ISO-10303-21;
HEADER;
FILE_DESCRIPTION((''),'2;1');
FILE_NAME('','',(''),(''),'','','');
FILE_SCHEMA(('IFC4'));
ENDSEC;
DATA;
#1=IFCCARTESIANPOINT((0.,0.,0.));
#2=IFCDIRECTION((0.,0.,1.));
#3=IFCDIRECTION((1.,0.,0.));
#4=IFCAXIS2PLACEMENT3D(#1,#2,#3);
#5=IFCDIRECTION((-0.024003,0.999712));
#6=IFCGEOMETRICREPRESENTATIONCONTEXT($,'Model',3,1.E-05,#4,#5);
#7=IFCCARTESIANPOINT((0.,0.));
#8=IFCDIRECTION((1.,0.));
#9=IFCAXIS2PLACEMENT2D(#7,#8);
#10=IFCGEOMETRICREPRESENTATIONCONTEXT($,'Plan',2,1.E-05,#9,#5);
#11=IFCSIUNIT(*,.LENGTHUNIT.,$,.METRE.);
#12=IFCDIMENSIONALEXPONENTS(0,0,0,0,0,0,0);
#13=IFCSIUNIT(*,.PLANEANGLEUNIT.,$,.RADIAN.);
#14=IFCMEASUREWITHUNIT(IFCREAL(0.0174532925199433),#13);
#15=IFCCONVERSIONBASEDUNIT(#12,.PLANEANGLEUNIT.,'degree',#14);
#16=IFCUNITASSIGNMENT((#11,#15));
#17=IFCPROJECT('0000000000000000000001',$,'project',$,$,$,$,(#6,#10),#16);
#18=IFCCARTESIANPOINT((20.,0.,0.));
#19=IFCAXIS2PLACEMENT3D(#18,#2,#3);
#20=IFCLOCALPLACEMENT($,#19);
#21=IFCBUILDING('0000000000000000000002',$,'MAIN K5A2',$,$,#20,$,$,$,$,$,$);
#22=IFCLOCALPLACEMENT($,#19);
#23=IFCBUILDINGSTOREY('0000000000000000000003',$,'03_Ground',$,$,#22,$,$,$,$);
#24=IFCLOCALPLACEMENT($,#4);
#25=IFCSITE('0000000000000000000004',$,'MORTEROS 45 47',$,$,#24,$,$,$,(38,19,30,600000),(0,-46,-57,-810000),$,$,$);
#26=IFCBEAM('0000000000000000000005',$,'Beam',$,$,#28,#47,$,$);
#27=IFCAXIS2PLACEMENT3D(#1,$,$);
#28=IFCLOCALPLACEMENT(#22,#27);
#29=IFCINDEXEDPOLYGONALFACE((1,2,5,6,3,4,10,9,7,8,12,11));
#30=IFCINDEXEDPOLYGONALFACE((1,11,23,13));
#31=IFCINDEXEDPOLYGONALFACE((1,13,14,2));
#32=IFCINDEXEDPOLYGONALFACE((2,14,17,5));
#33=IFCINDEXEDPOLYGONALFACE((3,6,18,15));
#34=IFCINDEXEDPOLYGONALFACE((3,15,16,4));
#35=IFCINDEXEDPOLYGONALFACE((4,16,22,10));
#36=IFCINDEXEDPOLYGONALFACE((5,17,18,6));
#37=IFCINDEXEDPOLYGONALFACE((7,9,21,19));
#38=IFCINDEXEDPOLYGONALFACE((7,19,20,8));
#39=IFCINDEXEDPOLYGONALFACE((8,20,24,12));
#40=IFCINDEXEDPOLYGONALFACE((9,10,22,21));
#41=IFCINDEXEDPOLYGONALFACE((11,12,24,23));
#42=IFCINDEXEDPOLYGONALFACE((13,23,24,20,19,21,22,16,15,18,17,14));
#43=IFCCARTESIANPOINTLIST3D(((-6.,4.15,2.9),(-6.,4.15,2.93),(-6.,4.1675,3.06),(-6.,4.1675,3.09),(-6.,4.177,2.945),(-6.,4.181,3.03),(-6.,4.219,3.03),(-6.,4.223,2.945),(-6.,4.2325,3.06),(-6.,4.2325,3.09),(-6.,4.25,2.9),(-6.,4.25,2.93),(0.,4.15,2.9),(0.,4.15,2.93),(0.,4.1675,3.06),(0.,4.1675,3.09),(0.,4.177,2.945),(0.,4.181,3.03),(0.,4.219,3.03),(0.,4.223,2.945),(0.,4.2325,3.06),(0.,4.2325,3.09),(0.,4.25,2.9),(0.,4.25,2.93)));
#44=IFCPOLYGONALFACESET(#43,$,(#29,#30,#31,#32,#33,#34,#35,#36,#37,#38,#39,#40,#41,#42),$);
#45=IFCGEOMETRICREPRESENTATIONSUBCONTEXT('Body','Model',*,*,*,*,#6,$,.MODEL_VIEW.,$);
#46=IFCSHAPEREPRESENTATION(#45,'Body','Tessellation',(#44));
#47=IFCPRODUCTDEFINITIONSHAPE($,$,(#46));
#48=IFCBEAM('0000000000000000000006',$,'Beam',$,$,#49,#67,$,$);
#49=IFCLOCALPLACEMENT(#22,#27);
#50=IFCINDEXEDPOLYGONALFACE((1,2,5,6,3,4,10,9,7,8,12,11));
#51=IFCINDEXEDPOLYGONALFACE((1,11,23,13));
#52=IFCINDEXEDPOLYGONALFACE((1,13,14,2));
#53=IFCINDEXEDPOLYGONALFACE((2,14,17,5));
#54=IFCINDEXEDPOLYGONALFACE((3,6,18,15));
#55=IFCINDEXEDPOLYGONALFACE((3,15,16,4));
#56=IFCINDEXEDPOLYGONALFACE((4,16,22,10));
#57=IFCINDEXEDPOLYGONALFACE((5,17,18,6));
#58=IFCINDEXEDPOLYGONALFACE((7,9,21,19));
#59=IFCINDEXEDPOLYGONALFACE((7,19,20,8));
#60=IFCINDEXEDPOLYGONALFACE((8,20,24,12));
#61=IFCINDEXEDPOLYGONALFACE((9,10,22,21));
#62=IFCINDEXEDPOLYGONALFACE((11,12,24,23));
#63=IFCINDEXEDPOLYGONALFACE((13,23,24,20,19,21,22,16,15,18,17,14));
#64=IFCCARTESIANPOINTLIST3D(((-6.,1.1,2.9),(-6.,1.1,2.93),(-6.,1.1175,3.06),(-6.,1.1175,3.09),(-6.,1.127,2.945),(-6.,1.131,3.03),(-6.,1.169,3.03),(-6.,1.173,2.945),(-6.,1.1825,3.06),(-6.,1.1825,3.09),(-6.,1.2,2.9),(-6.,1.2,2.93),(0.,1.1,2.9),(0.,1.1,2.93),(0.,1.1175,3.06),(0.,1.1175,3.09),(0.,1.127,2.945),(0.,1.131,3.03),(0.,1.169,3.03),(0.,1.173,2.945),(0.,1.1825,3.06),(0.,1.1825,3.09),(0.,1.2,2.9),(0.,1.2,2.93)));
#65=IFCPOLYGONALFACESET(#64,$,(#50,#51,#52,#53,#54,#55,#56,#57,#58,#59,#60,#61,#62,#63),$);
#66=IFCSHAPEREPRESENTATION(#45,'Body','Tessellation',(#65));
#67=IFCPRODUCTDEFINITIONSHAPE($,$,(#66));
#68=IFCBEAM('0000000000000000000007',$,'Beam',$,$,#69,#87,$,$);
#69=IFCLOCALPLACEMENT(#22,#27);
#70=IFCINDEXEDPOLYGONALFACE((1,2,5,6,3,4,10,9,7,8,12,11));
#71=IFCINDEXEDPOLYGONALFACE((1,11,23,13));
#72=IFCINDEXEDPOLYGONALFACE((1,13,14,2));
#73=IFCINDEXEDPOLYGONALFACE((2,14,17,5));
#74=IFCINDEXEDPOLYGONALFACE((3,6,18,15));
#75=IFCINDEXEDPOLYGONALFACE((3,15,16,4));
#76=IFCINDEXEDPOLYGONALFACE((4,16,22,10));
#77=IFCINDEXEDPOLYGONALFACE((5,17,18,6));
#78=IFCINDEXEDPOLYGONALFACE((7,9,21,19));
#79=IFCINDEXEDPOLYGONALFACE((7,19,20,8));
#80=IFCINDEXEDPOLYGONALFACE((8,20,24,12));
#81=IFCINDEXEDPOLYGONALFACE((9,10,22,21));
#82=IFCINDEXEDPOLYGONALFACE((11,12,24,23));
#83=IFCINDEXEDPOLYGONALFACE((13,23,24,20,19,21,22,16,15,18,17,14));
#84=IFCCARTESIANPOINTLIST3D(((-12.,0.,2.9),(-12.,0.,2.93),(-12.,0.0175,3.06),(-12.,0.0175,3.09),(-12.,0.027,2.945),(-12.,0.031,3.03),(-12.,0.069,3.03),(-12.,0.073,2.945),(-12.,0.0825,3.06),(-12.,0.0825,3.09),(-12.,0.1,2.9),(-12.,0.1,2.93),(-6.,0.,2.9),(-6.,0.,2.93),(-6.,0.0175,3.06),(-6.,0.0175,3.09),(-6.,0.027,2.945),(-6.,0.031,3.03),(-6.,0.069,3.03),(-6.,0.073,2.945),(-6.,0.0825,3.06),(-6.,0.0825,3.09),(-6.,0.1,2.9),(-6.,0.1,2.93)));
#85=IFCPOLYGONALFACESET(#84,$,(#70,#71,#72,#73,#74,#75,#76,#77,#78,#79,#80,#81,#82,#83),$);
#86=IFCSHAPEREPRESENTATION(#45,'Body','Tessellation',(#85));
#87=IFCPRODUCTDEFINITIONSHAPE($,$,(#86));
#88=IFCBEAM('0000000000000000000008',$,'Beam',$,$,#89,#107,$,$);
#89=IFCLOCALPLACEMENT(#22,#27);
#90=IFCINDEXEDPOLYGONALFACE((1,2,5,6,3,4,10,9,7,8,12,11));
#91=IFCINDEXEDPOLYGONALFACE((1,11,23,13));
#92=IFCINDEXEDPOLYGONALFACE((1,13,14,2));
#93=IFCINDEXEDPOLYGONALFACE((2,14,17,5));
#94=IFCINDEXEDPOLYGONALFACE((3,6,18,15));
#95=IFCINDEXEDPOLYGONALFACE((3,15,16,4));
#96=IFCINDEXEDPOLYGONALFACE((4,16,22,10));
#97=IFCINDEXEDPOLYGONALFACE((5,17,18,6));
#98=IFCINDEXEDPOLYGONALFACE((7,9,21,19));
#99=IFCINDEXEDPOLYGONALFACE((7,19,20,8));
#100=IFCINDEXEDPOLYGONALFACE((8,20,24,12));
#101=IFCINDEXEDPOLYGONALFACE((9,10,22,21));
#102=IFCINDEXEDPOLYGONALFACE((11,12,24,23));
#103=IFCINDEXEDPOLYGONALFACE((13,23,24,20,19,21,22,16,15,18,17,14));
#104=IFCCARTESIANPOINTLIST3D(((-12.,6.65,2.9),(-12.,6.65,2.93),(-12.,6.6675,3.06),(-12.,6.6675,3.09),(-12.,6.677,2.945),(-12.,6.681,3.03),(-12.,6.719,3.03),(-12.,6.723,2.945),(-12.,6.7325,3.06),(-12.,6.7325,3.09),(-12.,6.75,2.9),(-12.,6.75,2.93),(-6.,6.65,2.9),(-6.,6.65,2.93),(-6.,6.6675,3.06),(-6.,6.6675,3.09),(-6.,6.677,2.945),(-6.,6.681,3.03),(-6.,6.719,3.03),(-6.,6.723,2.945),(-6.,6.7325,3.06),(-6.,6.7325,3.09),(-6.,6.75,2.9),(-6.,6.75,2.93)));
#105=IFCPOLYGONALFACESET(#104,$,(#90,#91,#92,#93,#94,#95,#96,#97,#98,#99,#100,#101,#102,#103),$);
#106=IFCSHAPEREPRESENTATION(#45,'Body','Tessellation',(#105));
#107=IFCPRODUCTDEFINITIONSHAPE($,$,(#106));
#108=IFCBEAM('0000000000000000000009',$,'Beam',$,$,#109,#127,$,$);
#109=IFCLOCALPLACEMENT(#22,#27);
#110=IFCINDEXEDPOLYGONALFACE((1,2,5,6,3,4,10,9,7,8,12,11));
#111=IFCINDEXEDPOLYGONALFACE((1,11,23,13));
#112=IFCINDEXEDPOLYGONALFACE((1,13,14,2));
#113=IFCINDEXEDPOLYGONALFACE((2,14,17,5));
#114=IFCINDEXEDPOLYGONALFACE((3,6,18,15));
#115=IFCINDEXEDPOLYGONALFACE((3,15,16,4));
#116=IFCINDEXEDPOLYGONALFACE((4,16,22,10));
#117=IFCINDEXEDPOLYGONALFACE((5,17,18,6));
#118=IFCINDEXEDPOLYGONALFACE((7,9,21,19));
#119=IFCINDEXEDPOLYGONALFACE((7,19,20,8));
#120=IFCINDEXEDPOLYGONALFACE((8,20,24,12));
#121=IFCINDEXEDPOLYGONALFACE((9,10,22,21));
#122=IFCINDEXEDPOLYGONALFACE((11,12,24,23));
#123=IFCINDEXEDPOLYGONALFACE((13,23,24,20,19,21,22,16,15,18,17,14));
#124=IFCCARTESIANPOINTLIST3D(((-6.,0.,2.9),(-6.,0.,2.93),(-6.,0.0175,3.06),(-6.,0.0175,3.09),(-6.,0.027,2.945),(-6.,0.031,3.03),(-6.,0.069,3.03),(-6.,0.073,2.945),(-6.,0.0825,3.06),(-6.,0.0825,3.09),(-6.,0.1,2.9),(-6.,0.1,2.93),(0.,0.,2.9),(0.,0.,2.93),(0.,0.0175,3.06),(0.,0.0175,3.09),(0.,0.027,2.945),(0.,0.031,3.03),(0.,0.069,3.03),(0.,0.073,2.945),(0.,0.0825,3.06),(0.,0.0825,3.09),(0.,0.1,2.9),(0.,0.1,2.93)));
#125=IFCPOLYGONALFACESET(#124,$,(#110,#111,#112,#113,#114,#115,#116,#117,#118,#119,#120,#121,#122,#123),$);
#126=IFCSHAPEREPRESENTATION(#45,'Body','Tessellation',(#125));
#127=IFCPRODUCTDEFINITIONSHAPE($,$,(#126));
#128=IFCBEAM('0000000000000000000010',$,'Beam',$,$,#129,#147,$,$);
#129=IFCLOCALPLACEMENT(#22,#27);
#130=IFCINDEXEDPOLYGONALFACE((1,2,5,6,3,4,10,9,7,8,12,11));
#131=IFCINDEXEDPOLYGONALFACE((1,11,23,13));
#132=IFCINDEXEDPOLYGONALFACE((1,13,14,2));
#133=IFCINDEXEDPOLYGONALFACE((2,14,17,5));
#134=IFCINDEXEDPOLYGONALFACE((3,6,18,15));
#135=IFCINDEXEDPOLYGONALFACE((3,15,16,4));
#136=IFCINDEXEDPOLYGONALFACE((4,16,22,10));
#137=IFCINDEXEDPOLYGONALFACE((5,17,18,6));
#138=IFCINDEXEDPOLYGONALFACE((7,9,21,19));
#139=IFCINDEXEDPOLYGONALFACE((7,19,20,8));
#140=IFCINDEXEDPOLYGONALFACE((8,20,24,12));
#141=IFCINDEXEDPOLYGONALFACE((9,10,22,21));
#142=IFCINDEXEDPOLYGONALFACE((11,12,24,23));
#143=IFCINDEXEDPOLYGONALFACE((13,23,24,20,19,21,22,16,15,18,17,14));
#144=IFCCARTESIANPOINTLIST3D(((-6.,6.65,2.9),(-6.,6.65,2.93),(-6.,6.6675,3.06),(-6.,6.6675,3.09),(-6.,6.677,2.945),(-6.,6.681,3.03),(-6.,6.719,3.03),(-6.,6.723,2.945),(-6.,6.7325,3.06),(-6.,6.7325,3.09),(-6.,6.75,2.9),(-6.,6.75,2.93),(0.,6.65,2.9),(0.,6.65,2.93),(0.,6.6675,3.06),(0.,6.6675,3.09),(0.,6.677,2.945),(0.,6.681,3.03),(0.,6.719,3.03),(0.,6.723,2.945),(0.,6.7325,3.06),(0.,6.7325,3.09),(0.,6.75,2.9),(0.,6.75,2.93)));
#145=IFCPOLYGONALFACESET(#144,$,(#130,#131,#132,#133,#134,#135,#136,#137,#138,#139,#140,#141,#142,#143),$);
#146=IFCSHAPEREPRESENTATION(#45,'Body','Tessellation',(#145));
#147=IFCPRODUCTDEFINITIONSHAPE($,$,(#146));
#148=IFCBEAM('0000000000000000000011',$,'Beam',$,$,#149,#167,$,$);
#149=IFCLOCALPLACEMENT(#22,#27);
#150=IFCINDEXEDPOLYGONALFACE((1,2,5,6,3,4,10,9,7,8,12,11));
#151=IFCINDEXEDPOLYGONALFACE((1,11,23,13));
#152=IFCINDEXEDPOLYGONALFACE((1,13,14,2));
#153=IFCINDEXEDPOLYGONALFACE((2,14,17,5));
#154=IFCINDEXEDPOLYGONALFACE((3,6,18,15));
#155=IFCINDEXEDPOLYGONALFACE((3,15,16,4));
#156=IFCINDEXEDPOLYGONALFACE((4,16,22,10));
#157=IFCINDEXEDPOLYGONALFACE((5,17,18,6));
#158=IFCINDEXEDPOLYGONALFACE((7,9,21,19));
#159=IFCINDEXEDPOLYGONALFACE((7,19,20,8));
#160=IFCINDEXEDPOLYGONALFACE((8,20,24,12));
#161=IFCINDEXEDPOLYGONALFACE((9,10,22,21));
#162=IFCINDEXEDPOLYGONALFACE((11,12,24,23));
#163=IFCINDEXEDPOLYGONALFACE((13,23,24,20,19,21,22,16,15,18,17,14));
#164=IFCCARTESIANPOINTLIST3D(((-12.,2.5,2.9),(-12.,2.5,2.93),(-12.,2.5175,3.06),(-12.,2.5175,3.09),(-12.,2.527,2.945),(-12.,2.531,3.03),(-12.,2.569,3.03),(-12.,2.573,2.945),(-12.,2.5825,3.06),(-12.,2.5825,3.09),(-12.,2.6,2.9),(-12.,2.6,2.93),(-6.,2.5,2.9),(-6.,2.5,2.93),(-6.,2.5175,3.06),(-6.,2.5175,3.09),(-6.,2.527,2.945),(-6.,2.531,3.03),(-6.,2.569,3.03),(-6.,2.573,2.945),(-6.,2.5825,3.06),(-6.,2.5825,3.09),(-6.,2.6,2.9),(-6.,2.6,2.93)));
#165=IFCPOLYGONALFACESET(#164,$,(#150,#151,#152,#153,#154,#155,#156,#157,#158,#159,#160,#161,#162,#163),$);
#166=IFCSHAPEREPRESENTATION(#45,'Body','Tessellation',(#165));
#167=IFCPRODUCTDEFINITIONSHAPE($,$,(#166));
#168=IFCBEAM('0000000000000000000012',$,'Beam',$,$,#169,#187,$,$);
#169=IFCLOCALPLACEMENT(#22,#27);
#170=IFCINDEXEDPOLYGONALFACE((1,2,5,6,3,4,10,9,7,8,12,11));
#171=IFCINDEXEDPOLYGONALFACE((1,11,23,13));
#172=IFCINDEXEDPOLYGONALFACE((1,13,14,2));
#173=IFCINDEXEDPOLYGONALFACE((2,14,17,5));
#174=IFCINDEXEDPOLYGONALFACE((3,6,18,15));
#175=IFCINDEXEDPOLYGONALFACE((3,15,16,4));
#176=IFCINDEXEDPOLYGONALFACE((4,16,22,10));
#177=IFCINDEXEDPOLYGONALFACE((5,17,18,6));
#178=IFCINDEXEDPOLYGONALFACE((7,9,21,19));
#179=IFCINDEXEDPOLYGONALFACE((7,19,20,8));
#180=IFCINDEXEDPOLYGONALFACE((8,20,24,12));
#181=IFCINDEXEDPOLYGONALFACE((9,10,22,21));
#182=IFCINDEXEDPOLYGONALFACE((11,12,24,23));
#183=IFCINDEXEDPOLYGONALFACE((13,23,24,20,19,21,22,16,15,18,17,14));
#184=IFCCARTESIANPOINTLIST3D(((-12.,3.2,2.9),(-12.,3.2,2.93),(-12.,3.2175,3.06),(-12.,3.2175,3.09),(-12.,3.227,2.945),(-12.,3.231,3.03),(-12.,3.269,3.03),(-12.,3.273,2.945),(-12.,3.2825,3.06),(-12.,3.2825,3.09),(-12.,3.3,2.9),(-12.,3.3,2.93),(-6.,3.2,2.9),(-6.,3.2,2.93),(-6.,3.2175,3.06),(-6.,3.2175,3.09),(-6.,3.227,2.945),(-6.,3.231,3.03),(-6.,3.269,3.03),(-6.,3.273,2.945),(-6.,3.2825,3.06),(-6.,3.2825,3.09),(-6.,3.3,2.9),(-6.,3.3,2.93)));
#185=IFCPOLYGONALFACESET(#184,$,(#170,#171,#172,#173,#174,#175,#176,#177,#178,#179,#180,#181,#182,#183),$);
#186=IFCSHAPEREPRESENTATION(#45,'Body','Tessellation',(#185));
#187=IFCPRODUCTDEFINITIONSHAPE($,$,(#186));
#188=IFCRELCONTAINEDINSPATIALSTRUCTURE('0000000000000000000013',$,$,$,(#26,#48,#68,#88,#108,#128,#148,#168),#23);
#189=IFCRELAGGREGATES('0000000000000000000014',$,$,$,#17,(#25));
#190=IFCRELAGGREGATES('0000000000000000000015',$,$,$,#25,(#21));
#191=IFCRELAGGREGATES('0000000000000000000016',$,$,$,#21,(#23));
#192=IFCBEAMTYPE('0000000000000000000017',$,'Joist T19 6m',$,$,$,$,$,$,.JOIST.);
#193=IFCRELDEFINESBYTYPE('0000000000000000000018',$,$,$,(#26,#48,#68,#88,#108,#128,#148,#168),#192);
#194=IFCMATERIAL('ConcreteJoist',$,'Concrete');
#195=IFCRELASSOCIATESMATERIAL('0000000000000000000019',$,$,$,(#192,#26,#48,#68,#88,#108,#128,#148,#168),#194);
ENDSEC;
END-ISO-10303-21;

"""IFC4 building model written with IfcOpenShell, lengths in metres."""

from ifc_helpers import new_model, entity, si_unit, converted_unit, direction, frame, origin_with_axes, origin_2d_with_axis, place, context, subcontext, project, spatial, indexed_curve, outline, extrude, material, material_profile, profile_set, profile_usage, type_object, element, save


model = new_model("IFC4")

# Units and contexts
model_context = context("Model", 3, precision=1e-05, world=origin_with_axes(), true_north=direction((-0.024003, 0.999712)))
plan_context = context("Plan", 2, precision=1e-05, world=origin_2d_with_axis(), true_north=direction((-0.024003, 0.999712)))
body_context_1 = subcontext(model_context, "Body", "Model", "MODEL_VIEW")
ifc_project = project(units=[si_unit("LENGTHUNIT", "METRE"), converted_unit("PLANEANGLEUNIT", "degree", entity("IfcReal", 0.0174532925199433), si_unit("PLANEANGLEUNIT", "RADIAN"), dimensions=[0, 0, 0, 0, 0, 0, 0])], contexts=[model_context, plan_context])

# Site, building, storey
site_placement = place(None, origin_with_axes())
site = spatial("IfcSite", under=ifc_project, at=site_placement, Name="MORTEROS 45 47", RefLatitude=(38, 19, 30, 600000), RefLongitude=(0, -46, -57, -810000))
building_placement = place(None, frame((20.0, 0.0, 0.0), z_axis=(0.0, 0.0, 1.0), x_axis=(1.0, 0.0, 0.0)))
building = spatial("IfcBuilding", under=site, at=building_placement, Name="MAIN K5A2")
storey_placement = place(None, frame((20.0, 0.0, 0.0), z_axis=(0.0, 0.0, 1.0), x_axis=(1.0, 0.0, 0.0)))
storey = spatial("IfcBuildingStorey", under=building, at=storey_placement, Name="03_Ground")

# Beams
ifc_material = material(Name="ConcreteJoist", Category="Concrete")
ifc_material_profile = material_profile(ifc_material, outline(indexed_curve([(0.019, 0.13), (0.023, 0.045), (0.05, 0.03), (0.05, 0.0), (-0.05, 0.0), (-0.05, 0.03), (-0.023, 0.045), (-0.019, 0.13), (-0.0325, 0.16), (-0.0325, 0.19), (0.0325, 0.19), (0.0325, 0.16), (0.019, 0.13)])))
ifc_profile_set = profile_set([ifc_material_profile], Name="JoistmaterialProfile")
beam_type = type_object("IfcBeamType", Name="Joist T19 6m", PredefinedType="JOIST", material=ifc_profile_set)
ifc_profile_usage_1 = profile_usage(ifc_profile_set)
beam_1_placement = place(None, frame((14.0, 4.2, 2.9), z_axis=(1.0, 0.0, 0.0), x_axis=(0.0, 1.0, 0.0)))
element("IfcBeam", 1, at=beam_1_placement, inside=storey, type_object=beam_type, material=ifc_profile_usage_1, Name="Beam", context=body_context_1, shape_type="SweptSolid", body=[
    extrude(outline(indexed_curve([(0.019, 0.13), (0.023, 0.045), (0.05, 0.03), (0.05, 0.0), (-0.05, 0.0), (-0.05, 0.03), (-0.023, 0.045), (-0.019, 0.13), (-0.0325, 0.16), (-0.0325, 0.19), (0.0325, 0.19), (0.0325, 0.16), (0.019, 0.13)])), origin_with_axes(), (0.0, 0.0, 1.0), 6.0),
])
ifc_profile_usage_2 = profile_usage(ifc_profile_set)
beam_2_placement = place(None, frame((14.0, 1.15, 2.9), z_axis=(1.0, 0.0, 0.0), x_axis=(0.0, 1.0, 0.0)))
element("IfcBeam", 2, at=beam_2_placement, inside=storey, type_object=beam_type, material=ifc_profile_usage_2, Name="Beam", context=body_context_1, shape_type="SweptSolid", body=[
    extrude(outline(indexed_curve([(0.019, 0.13), (0.023, 0.045), (0.05, 0.03), (0.05, 0.0), (-0.05, 0.0), (-0.05, 0.03), (-0.023, 0.045), (-0.019, 0.13), (-0.0325, 0.16), (-0.0325, 0.19), (0.0325, 0.19), (0.0325, 0.16), (0.019, 0.13)])), origin_with_axes(), (0.0, 0.0, 1.0), 6.0),
])
ifc_profile_usage_3 = profile_usage(ifc_profile_set)
beam_3_placement = place(None, frame((8.0, 0.05, 2.9), z_axis=(1.0, 0.0, 0.0), x_axis=(0.0, 1.0, 0.0)))
element("IfcBeam", 3, at=beam_3_placement, inside=storey, type_object=beam_type, material=ifc_profile_usage_3, Name="Beam", context=body_context_1, shape_type="SweptSolid", body=[
    extrude(outline(indexed_curve([(0.019, 0.13), (0.023, 0.045), (0.05, 0.03), (0.05, 0.0), (-0.05, 0.0), (-0.05, 0.03), (-0.023, 0.045), (-0.019, 0.13), (-0.0325, 0.16), (-0.0325, 0.19), (0.0325, 0.19), (0.0325, 0.16), (0.019, 0.13)])), origin_with_axes(), (0.0, 0.0, 1.0), 6.0),
])
ifc_profile_usage_4 = profile_usage(ifc_profile_set)
beam_4_placement = place(None, frame((8.0, 6.7, 2.9), z_axis=(1.0, 0.0, 0.0), x_axis=(0.0, 1.0, 0.0)))
element("IfcBeam", 4, at=beam_4_placement, inside=storey, type_object=beam_type, material=ifc_profile_usage_4, Name="Beam", context=body_context_1, shape_type="SweptSolid", body=[
    extrude(outline(indexed_curve([(0.019, 0.13), (0.023, 0.045), (0.05, 0.03), (0.05, 0.0), (-0.05, 0.0), (-0.05, 0.03), (-0.023, 0.045), (-0.019, 0.13), (-0.0325, 0.16), (-0.0325, 0.19), (0.0325, 0.19), (0.0325, 0.16), (0.019, 0.13)])), origin_with_axes(), (0.0, 0.0, 1.0), 6.0),
])
ifc_profile_usage_5 = profile_usage(ifc_profile_set)
beam_5_placement = place(None, frame((14.0, 0.05, 2.9), z_axis=(1.0, 0.0, 0.0), x_axis=(0.0, 1.0, 0.0)))
element("IfcBeam", 5, at=beam_5_placement, inside=storey, type_object=beam_type, material=ifc_profile_usage_5, Name="Beam", context=body_context_1, shape_type="SweptSolid", body=[
    extrude(outline(indexed_curve([(0.019, 0.13), (0.023, 0.045), (0.05, 0.03), (0.05, 0.0), (-0.05, 0.0), (-0.05, 0.03), (-0.023, 0.045), (-0.019, 0.13), (-0.0325, 0.16), (-0.0325, 0.19), (0.0325, 0.19), (0.0325, 0.16), (0.019, 0.13)])), origin_with_axes(), (0.0, 0.0, 1.0), 6.0),
])
ifc_profile_usage_6 = profile_usage(ifc_profile_set)
beam_6_placement = place(None, frame((14.0, 6.7, 2.9), z_axis=(1.0, 0.0, 0.0), x_axis=(0.0, 1.0, 0.0)))
element("IfcBeam", 6, at=beam_6_placement, inside=storey, type_object=beam_type, material=ifc_profile_usage_6, Name="Beam", context=body_context_1, shape_type="SweptSolid", body=[
    extrude(outline(indexed_curve([(0.019, 0.13), (0.023, 0.045), (0.05, 0.03), (0.05, 0.0), (-0.05, 0.0), (-0.05, 0.03), (-0.023, 0.045), (-0.019, 0.13), (-0.0325, 0.16), (-0.0325, 0.19), (0.0325, 0.19), (0.0325, 0.16), (0.019, 0.13)])), origin_with_axes(), (0.0, 0.0, 1.0), 6.0),
])
ifc_profile_usage_7 = profile_usage(ifc_profile_set)
beam_7_placement = place(None, frame((8.0, 2.55, 2.9), z_axis=(1.0, 0.0, 0.0), x_axis=(0.0, 1.0, 0.0)))
element("IfcBeam", 7, at=beam_7_placement, inside=storey, type_object=beam_type, material=ifc_profile_usage_7, Name="Beam", context=body_context_1, shape_type="SweptSolid", body=[
    extrude(outline(indexed_curve([(0.019, 0.13), (0.023, 0.045), (0.05, 0.03), (0.05, 0.0), (-0.05, 0.0), (-0.05, 0.03), (-0.023, 0.045), (-0.019, 0.13), (-0.0325, 0.16), (-0.0325, 0.19), (0.0325, 0.19), (0.0325, 0.16), (0.019, 0.13)])), origin_with_axes(), (0.0, 0.0, 1.0), 6.0),
])
ifc_profile_usage_8 = profile_usage(ifc_profile_set)
beam_8_placement = place(None, frame((8.0, 3.25, 2.9), z_axis=(1.0, 0.0, 0.0), x_axis=(0.0, 1.0, 0.0)))
element("IfcBeam", 8, at=beam_8_placement, inside=storey, type_object=beam_type, material=ifc_profile_usage_8, Name="Beam", context=body_context_1, shape_type="SweptSolid", body=[
    extrude(outline(indexed_curve([(0.019, 0.13), (0.023, 0.045), (0.05, 0.03), (0.05, 0.0), (-0.05, 0.0), (-0.05, 0.03), (-0.023, 0.045), (-0.019, 0.13), (-0.0325, 0.16), (-0.0325, 0.19), (0.0325, 0.19), (0.0325, 0.16), (0.019, 0.13)])), origin_with_axes(), (0.0, 0.0, 1.0), 6.0),
])

save(model, "model.ifc")
